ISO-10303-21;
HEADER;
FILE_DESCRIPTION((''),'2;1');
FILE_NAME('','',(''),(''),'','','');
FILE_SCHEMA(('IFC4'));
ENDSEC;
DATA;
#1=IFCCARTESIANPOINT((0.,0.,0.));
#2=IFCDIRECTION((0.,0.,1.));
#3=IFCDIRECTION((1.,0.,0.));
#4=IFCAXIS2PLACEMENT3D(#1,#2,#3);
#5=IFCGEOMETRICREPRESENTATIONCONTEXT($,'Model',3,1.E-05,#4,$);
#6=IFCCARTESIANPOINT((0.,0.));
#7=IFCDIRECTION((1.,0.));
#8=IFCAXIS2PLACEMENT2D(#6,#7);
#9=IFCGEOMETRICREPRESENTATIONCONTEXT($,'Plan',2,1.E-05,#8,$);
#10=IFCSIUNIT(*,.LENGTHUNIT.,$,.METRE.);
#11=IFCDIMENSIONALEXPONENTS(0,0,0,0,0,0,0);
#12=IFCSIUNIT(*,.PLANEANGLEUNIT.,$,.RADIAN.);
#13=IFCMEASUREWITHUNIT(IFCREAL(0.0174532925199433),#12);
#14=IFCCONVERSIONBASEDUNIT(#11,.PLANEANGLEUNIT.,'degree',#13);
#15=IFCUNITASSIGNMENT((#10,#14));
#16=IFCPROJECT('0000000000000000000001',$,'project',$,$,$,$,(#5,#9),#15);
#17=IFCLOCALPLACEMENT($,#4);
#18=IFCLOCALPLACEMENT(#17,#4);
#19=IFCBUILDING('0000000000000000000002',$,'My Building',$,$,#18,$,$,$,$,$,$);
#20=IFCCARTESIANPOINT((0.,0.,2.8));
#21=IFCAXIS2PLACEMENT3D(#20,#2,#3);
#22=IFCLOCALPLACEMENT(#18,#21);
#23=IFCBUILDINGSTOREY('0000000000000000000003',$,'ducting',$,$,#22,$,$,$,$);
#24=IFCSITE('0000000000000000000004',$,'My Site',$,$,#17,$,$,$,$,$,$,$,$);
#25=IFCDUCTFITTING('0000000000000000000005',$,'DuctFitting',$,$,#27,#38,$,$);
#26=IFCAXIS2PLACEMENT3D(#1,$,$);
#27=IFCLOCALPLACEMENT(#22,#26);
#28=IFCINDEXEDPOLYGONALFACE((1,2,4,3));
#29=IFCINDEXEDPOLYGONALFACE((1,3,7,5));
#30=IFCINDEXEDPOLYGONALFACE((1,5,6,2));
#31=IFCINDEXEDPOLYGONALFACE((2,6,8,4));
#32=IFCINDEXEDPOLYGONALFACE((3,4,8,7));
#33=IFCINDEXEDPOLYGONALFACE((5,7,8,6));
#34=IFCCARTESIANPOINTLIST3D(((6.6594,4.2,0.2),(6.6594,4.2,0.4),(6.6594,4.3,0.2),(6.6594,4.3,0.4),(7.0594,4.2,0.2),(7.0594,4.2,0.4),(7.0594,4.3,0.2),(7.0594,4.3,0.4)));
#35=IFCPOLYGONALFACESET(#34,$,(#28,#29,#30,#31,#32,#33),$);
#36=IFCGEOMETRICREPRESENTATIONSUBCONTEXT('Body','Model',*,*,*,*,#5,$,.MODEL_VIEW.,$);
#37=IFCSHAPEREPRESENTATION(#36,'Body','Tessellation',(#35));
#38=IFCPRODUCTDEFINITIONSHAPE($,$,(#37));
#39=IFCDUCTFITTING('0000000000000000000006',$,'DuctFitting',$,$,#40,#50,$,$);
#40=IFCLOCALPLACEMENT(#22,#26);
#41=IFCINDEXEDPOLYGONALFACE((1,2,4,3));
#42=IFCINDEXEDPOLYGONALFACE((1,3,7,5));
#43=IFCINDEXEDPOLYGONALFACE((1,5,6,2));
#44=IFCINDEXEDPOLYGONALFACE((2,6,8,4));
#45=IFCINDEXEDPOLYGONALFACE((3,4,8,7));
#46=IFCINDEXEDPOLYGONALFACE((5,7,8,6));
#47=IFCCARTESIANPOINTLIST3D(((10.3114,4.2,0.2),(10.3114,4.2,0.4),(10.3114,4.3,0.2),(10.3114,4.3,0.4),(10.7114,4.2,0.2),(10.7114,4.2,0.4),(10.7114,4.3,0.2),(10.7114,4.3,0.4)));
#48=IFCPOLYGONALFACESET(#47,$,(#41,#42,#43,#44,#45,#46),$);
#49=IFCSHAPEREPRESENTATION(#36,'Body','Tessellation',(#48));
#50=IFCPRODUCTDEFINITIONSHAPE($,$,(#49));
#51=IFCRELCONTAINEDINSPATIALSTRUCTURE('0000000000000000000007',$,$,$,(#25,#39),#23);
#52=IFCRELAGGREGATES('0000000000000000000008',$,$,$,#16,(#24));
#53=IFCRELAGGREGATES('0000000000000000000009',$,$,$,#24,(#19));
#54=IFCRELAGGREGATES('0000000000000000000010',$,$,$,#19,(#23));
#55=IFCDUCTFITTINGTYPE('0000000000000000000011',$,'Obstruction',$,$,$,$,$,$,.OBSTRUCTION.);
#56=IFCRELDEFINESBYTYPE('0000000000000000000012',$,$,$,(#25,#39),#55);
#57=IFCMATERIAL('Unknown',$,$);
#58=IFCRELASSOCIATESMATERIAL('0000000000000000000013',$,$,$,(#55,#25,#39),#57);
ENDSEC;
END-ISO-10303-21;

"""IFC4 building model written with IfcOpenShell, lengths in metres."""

from ifc_helpers import new_model, entity, si_unit, converted_unit, frame, origin_with_axes, origin_2d_with_axis, place, context, subcontext, project, spatial, rectangle, extrude, material, material_profile, profile_set, profile_usage, type_object, element, save


model = new_model("IFC4")

# Units and contexts
model_context = context("Model", 3, precision=1e-05, world=origin_with_axes())
plan_context = context("Plan", 2, precision=1e-05, world=origin_2d_with_axis())
body_context = subcontext(model_context, "Body", "Model", "MODEL_VIEW")
ifc_project = project(units=[si_unit("LENGTHUNIT", "METRE"), converted_unit("PLANEANGLEUNIT", "degree", entity("IfcReal", 0.0174532925199433), si_unit("PLANEANGLEUNIT", "RADIAN"), dimensions=[0, 0, 0, 0, 0, 0, 0])], contexts=[model_context, plan_context])

# Site, building, storey
site_placement = place(None, origin_with_axes())
site = spatial("IfcSite", under=ifc_project, at=site_placement, Name="My Site")
building_placement = place(site_placement, origin_with_axes())
building = spatial("IfcBuilding", under=site, at=building_placement, Name="My Building")
storey_placement = place(building_placement, frame((0.0, 0.0, 2.8), z_axis=(0.0, 0.0, 1.0), x_axis=(1.0, 0.0, 0.0)))
storey = spatial("IfcBuildingStorey", under=building, at=storey_placement, Name="ducting")

# Shared definitions
ifc_material = material(Name="Unknown")

# Duct fittings
ifc_material_profile_1 = material_profile(ifc_material, rectangle(XDim=0.4, YDim=0.2))
ifc_profile_set_1 = profile_set([ifc_material_profile_1])
duct_fitting_type_1 = type_object("IfcDuctFittingType", Name="Obstruction", PredefinedType="OBSTRUCTION", material=ifc_profile_set_1)
ifc_profile_usage_1 = profile_usage(ifc_profile_set_1, cardinal=5)
duct_fitting_1_placement = place(storey_placement, frame((6.8594, 4.3, 0.3), z_axis=(0.0, -1.0, 0.0), x_axis=(1.0, 0.0, 0.0)))
element("IfcDuctFitting", 1, at=duct_fitting_1_placement, inside=storey, type_object=duct_fitting_type_1, material=ifc_profile_usage_1, Name="DuctFitting", context=body_context, shape_type="SweptSolid", body=[
    extrude(rectangle(XDim=0.4, YDim=0.2), origin_with_axes(), (0.0, 0.0, 1.0), 0.1),
])
ifc_profile_usage_2 = profile_usage(ifc_profile_set_1, cardinal=5)
duct_fitting_2_placement = place(storey_placement, frame((10.5114, 4.3, 0.3), z_axis=(0.0, -1.0, 0.0), x_axis=(1.0, 0.0, 0.0)))
element("IfcDuctFitting", 2, at=duct_fitting_2_placement, inside=storey, type_object=duct_fitting_type_1, material=ifc_profile_usage_2, Name="DuctFitting", context=body_context, shape_type="SweptSolid", body=[
    extrude(rectangle(XDim=0.4, YDim=0.2), origin_with_axes(), (0.0, 0.0, 1.0), 0.1),
])

save(model, "model.ifc")
